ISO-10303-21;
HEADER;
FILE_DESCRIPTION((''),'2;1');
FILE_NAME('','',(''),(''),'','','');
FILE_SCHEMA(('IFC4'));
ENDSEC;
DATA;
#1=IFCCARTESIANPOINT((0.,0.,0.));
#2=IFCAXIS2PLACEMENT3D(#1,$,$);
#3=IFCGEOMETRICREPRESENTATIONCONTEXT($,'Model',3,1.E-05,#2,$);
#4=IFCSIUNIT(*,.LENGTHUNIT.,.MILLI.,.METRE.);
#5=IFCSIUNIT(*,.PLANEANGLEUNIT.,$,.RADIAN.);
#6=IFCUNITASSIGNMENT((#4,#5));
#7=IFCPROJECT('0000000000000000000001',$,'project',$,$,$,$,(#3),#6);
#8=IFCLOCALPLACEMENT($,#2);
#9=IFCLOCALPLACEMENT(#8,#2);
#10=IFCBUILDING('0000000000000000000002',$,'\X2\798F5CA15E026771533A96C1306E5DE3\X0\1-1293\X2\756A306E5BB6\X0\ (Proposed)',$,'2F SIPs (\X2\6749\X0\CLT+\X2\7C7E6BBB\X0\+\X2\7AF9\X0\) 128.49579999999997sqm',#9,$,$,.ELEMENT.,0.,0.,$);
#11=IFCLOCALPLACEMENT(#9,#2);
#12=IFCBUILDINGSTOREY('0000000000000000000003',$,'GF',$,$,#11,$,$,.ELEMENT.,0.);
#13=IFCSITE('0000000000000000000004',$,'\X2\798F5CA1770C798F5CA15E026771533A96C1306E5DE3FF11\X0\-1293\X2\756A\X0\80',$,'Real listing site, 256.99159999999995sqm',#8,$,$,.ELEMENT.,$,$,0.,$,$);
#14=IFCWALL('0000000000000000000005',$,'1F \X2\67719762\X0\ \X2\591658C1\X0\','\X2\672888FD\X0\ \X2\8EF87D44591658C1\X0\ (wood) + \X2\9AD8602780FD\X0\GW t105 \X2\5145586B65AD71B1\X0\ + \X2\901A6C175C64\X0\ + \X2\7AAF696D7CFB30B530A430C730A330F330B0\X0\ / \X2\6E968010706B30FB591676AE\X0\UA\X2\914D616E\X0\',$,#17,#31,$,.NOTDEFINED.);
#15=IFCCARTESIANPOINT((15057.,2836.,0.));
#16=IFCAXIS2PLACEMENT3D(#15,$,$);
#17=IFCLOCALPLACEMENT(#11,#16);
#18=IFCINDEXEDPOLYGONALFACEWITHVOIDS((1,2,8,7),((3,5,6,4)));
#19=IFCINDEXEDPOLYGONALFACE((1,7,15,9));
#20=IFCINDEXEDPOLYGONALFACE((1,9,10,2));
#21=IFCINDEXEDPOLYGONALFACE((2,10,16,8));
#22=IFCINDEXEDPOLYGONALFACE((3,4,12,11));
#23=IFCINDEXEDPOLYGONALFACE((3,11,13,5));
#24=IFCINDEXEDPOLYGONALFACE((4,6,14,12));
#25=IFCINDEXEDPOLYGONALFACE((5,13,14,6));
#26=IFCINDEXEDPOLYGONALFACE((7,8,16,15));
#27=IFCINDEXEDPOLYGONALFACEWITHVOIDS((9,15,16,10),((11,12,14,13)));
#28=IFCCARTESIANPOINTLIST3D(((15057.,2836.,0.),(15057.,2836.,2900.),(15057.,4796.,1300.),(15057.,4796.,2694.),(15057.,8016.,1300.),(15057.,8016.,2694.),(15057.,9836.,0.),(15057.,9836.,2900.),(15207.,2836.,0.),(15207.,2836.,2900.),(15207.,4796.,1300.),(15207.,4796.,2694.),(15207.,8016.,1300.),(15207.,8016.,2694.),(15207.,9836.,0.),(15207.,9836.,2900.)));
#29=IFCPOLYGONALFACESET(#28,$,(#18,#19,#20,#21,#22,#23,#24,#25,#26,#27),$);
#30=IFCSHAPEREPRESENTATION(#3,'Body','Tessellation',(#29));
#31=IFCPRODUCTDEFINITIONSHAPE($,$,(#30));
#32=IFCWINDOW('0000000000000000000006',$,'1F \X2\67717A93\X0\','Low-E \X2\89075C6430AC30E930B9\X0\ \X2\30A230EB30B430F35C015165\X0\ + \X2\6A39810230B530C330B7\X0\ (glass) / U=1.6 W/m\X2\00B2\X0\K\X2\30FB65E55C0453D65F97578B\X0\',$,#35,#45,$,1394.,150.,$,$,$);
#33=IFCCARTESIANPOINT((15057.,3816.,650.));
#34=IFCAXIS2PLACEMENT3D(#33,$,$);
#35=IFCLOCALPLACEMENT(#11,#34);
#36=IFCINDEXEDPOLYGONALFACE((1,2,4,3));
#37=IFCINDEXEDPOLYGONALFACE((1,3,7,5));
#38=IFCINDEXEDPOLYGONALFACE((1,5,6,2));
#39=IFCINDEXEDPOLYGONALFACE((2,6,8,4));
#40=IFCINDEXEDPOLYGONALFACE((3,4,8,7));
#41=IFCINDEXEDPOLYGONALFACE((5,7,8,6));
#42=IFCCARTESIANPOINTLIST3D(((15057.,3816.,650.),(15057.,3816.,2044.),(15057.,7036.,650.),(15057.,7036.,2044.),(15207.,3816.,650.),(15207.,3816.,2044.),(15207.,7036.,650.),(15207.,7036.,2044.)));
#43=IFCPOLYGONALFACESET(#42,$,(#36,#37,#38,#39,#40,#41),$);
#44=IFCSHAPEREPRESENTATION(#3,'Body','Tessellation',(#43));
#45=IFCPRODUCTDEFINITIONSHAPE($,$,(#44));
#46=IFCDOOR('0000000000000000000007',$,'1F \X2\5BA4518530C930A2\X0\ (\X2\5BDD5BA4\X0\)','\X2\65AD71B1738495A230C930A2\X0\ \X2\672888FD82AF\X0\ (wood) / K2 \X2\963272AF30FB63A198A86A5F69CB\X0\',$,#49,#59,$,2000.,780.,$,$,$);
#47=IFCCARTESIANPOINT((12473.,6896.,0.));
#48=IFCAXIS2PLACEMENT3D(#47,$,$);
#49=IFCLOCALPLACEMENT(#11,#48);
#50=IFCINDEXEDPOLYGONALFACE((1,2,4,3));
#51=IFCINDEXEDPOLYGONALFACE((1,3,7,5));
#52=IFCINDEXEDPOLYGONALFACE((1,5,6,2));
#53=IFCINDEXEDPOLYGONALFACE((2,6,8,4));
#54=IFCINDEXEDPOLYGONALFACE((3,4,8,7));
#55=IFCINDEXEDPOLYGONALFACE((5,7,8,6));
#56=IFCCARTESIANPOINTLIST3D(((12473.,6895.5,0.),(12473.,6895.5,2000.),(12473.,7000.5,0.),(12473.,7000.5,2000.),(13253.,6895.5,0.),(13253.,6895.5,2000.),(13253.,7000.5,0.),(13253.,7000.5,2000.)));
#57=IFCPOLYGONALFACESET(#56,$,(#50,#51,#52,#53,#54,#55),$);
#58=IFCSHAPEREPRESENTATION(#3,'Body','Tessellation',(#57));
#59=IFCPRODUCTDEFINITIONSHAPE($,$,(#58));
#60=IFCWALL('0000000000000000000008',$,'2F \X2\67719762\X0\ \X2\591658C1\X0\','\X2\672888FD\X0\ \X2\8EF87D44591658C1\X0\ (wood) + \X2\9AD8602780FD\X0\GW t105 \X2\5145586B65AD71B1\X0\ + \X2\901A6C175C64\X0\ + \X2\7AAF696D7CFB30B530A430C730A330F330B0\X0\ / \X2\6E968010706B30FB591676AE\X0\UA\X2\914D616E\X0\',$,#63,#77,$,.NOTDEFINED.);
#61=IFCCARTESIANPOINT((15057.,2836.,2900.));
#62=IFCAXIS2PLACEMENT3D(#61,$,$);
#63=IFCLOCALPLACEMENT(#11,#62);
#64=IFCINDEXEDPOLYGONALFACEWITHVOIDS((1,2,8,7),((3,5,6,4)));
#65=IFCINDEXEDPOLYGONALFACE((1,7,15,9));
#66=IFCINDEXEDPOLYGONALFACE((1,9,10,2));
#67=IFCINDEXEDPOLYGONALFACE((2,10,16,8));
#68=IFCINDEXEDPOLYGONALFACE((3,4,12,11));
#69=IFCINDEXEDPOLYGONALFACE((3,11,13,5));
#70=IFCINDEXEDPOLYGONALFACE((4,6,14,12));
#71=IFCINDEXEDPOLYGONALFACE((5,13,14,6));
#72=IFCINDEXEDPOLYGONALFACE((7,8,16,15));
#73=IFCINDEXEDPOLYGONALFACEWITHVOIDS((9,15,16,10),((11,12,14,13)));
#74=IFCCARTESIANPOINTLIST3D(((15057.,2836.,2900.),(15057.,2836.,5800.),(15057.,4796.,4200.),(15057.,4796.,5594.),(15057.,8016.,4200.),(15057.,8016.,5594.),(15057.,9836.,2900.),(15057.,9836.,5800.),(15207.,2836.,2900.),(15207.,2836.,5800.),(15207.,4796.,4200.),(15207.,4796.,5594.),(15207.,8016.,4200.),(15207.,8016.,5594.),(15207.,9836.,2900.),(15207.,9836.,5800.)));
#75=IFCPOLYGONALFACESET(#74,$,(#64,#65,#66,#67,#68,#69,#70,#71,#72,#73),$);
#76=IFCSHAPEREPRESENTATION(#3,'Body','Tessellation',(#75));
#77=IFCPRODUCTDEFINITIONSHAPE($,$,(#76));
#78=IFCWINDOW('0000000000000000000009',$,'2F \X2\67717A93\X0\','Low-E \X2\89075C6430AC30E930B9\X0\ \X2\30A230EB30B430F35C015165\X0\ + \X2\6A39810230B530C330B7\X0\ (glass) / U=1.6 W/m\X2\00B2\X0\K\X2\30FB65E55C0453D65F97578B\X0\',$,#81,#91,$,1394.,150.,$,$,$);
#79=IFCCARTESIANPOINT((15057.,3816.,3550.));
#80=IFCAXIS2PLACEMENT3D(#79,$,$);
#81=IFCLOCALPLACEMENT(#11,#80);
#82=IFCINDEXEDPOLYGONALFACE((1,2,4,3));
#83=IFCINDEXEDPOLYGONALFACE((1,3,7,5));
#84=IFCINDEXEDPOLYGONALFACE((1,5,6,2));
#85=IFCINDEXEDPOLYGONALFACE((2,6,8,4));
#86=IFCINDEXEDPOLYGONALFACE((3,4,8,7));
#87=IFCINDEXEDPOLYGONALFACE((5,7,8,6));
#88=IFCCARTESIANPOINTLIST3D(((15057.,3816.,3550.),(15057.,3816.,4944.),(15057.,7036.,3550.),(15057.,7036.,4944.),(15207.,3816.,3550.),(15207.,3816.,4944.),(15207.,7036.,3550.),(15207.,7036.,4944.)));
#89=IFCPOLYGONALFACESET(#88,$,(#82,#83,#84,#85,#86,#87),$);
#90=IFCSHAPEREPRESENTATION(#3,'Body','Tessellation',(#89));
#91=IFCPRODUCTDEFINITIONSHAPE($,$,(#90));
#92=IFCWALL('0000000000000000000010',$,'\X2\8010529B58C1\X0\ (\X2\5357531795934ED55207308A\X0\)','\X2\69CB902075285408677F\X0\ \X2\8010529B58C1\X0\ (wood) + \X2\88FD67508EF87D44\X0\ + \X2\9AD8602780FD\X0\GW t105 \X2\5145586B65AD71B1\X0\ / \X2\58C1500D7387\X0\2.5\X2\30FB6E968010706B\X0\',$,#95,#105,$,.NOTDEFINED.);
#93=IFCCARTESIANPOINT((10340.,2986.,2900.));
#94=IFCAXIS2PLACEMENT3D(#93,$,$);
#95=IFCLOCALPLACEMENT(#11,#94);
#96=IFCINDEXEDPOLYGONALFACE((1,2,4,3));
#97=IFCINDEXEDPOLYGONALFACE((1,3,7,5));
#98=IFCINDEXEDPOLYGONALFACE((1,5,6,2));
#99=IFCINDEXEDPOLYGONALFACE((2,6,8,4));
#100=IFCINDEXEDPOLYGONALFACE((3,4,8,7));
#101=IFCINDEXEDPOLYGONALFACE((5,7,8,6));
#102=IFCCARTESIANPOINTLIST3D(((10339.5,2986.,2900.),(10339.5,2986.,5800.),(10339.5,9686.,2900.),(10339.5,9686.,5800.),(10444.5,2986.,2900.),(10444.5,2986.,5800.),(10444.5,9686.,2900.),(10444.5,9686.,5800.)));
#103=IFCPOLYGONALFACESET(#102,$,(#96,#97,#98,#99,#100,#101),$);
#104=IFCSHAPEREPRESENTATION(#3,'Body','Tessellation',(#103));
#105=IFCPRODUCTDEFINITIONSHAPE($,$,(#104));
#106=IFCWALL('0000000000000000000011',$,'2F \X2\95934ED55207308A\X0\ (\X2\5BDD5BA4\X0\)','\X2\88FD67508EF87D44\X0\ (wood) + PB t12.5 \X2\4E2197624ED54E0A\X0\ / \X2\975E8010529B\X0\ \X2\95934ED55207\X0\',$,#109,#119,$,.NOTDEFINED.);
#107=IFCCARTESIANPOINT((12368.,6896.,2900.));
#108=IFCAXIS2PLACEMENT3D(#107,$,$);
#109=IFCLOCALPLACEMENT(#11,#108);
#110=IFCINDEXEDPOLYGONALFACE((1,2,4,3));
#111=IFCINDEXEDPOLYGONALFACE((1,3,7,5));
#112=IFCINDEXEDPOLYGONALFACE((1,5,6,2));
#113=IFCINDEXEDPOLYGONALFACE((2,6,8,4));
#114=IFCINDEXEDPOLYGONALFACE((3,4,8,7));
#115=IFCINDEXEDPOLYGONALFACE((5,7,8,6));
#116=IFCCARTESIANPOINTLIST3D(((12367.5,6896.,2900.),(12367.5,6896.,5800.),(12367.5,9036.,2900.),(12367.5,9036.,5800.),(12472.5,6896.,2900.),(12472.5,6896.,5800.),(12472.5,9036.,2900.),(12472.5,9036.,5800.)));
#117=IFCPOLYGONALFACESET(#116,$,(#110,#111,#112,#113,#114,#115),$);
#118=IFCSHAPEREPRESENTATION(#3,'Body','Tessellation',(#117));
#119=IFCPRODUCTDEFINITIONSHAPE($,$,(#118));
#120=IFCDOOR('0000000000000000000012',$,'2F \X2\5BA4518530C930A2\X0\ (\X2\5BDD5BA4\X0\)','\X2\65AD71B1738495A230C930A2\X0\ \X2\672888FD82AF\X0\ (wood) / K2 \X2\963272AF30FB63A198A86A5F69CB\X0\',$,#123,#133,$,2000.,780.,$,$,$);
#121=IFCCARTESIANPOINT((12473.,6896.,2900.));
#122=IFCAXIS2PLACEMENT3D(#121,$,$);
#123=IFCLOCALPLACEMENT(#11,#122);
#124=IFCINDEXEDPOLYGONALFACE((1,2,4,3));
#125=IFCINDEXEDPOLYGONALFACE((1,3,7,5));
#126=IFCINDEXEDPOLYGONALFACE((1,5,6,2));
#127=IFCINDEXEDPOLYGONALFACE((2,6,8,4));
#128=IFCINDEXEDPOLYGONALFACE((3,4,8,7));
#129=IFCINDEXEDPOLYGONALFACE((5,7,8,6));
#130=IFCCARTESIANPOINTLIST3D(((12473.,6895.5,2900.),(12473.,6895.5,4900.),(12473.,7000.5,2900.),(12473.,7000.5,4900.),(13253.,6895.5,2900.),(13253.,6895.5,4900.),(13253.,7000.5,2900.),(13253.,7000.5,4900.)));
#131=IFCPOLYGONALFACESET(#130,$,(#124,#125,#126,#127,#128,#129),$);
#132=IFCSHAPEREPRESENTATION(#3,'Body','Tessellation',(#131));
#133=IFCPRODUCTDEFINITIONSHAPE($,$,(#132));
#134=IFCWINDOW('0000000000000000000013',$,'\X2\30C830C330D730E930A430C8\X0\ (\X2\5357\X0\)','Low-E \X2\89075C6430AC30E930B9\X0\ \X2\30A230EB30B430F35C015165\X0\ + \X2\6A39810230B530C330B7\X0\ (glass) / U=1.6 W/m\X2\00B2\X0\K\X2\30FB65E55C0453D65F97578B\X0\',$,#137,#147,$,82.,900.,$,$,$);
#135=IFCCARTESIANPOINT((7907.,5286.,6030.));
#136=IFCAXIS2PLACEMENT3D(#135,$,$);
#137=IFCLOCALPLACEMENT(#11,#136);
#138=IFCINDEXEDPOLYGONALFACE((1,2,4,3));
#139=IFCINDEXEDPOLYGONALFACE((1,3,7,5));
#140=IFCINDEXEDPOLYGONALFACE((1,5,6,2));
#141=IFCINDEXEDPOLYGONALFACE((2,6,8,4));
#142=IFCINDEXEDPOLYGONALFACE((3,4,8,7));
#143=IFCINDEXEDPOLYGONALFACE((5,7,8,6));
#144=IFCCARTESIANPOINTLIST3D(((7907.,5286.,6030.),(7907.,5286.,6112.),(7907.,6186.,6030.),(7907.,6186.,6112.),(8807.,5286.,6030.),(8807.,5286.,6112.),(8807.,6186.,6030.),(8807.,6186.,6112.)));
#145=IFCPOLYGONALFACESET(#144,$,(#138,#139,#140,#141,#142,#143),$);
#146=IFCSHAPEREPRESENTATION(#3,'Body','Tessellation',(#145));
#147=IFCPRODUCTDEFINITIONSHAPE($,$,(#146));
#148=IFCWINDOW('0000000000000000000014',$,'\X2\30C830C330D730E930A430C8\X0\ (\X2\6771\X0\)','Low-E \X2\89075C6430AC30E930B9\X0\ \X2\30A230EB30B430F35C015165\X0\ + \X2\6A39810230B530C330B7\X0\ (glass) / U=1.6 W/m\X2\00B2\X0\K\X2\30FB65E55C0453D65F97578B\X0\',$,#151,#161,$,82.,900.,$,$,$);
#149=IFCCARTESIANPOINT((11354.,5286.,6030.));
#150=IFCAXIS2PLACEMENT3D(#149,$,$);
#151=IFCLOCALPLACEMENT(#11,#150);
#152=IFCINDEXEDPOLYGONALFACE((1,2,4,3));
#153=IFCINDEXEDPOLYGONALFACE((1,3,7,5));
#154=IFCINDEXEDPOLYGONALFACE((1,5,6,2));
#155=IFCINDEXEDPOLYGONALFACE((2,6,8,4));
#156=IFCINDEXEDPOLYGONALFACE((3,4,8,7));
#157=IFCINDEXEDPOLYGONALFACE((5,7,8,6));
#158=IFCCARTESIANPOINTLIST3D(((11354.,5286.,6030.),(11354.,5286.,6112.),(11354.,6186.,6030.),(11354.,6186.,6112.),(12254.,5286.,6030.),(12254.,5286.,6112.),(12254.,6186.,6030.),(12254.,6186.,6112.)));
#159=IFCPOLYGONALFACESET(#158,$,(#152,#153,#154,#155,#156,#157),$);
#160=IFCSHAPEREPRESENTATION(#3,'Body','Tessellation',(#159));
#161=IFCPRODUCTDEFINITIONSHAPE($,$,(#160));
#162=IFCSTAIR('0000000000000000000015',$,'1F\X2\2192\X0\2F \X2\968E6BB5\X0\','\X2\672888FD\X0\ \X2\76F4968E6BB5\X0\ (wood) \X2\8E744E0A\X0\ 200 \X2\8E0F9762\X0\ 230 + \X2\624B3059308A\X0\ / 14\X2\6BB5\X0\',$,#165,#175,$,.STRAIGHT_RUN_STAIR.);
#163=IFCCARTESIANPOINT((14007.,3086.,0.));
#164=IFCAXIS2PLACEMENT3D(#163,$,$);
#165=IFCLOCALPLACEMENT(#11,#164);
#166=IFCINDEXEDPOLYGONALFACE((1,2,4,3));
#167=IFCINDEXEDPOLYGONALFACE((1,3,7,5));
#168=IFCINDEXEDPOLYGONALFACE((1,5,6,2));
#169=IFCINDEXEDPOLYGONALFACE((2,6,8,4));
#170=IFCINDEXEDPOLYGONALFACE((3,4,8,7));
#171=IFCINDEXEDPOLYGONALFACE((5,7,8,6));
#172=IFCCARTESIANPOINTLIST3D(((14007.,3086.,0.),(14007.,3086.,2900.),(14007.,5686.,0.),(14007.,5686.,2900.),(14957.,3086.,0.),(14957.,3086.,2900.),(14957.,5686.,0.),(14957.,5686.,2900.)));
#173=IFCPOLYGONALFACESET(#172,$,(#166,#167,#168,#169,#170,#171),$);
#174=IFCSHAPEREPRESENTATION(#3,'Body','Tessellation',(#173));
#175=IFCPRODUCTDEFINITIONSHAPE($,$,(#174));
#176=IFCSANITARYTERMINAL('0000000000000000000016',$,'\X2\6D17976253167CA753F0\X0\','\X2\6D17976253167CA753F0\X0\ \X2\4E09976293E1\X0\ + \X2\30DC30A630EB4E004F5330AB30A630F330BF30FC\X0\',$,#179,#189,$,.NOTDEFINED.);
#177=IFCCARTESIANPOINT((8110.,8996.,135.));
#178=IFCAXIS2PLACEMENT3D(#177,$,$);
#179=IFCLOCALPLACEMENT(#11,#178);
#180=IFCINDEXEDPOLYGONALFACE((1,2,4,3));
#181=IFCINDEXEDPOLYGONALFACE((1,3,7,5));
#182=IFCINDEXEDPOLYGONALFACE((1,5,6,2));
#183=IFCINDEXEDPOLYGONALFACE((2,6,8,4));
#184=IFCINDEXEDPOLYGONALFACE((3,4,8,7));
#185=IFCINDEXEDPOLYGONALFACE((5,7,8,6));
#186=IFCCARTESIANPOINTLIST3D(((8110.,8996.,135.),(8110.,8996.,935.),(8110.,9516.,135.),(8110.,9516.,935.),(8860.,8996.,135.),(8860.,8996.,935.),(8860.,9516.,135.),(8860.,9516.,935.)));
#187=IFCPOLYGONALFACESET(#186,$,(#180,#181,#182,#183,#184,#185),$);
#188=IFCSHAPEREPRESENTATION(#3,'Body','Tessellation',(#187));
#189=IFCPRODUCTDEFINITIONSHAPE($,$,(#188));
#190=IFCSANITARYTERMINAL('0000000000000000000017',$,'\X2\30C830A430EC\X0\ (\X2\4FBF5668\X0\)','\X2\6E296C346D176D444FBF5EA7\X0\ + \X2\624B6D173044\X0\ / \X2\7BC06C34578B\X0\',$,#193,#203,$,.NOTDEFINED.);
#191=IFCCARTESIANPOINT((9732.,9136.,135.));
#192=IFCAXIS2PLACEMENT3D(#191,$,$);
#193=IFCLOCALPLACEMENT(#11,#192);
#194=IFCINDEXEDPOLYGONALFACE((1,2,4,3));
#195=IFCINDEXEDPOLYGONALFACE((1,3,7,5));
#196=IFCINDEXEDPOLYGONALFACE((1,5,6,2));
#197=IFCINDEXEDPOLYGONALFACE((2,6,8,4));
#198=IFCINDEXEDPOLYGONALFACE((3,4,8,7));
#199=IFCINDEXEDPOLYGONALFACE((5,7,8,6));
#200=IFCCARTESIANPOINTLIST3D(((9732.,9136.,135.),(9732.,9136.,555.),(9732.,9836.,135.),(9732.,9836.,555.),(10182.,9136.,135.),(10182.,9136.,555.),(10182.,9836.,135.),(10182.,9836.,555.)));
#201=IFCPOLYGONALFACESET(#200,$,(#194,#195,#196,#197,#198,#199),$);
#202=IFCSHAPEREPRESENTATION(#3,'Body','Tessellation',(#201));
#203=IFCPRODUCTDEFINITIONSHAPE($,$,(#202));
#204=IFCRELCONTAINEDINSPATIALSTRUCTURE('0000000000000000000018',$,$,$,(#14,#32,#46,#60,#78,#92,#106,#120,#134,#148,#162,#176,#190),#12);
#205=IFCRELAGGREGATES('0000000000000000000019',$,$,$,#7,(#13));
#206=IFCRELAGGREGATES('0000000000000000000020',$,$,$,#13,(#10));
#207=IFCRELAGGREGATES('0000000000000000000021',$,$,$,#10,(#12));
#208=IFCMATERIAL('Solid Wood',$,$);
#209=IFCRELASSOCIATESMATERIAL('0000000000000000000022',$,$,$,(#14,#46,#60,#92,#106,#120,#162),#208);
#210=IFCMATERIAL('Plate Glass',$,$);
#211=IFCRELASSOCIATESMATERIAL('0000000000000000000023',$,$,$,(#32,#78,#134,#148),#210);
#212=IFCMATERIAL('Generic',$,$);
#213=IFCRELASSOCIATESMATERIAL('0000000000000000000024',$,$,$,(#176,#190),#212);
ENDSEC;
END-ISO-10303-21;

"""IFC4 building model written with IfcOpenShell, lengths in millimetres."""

from ifc_helpers import new_model, si_unit, frame, frame_2d, origin, place, context, project, spatial, rectangle, extrude, material, element, fill, save


model = new_model("IFC4")

# Units and contexts
model_context = context("Model", 3, precision=1e-05, world=origin())
ifc_project = project(units=[si_unit("LENGTHUNIT", "METRE", prefix="MILLI"), si_unit("PLANEANGLEUNIT", "RADIAN")], contexts=[model_context])

# Site, building, storey
site_placement = place(None, origin())
site = spatial("IfcSite", under=ifc_project, at=site_placement, Name="福岡県福岡市東区雁の巣１-1293番80", ObjectType="Real listing site, 256.99159999999995sqm", CompositionType="ELEMENT", RefElevation=0.0)
building_placement = place(site_placement, origin())
building = spatial("IfcBuilding", under=site, at=building_placement, Name="福岡市東区雁の巣1-1293番の家 (Proposed)", ObjectType="2F SIPs (杉CLT+籾殻+竹) 128.49579999999997sqm", CompositionType="ELEMENT", ElevationOfRefHeight=0.0, ElevationOfTerrain=0.0)
storey_placement = place(building_placement, origin())
storey = spatial("IfcBuildingStorey", under=building, at=storey_placement, Name="GF", CompositionType="ELEMENT", Elevation=0.0)

# Wall, opening, window
ifc_material_1 = material(Name="Solid Wood")
wall_1_placement = place(storey_placement, frame((15057.0, 2836.0, 0.0)))
wall_1 = element("IfcWall", 1, at=wall_1_placement, inside=storey, material=ifc_material_1, Name="1F 東面 外壁", Description="木製 軸組外壁 (wood) + 高性能GW t105 充填断熱 + 通気層 + 窯業系サイディング / 準耐火・外皮UA配慮", PredefinedType="NOTDEFINED", context=model_context, shape_type="SweptSolid", body=[
    extrude(rectangle(XDim=150.0, YDim=7000.0, at=frame_2d((75.0, 3500.0))), frame((15057.0, 2836.0, 0.0)), (0.0, 0.0, 1.0), 2900.0),
])
opening_1_placement = place(storey_placement, frame((15057.0, 3816.0, 650.0)))
opening_1 = element("IfcOpeningElement", 2, at=opening_1_placement, cuts=wall_1, PredefinedType="NOTDEFINED", context=model_context, shape_type="SweptSolid", body=[
    extrude(rectangle(XDim=150.0, YDim=3220.0, at=frame_2d((75.0, 1610.0))), frame((15057.0, 3816.0, 650.0)), (0.0, 0.0, 1.0), 1394.0),
])
ifc_material_2 = material(Name="Plate Glass")
window_1_placement = place(storey_placement, frame((15057.0, 3816.0, 650.0)))
window_1 = element("IfcWindow", 3, at=window_1_placement, inside=storey, material=ifc_material_2, Name="1F 東窓", Description="Low-E 複層ガラス アルゴン封入 + 樹脂サッシ (glass) / U=1.6 W/m²K・日射取得型", OverallHeight=1394.0, OverallWidth=150.0, context=model_context, shape_type="SweptSolid", body=[
    extrude(rectangle(XDim=150.0, YDim=3220.0, at=frame_2d((75.0, 1610.0))), frame((15057.0, 3816.0, 650.0)), (0.0, 0.0, 1.0), 1394.0),
])
fill(opening_1, window_1)

# Door
door_1_placement = place(storey_placement, frame((12473.0, 6896.0, 0.0)))
element("IfcDoor", 4, at=door_1_placement, inside=storey, material=ifc_material_1, Name="1F 室内ドア (寝室)", Description="断熱玄関ドア 木製芯 (wood) / K2 防犯・採風機構", OverallHeight=2000.0, OverallWidth=780.0, context=model_context, shape_type="SweptSolid", body=[
    extrude(rectangle(XDim=780.0, YDim=105.0, at=frame_2d((390.0, 52.0))), frame((12473.0, 6896.0, 0.0)), (0.0, 0.0, 1.0), 2000.0),
])

# Wall, opening, window
wall_2_placement = place(storey_placement, frame((15057.0, 2836.0, 2900.0)))
wall_2 = element("IfcWall", 5, at=wall_2_placement, inside=storey, material=ifc_material_1, Name="2F 東面 外壁", Description="木製 軸組外壁 (wood) + 高性能GW t105 充填断熱 + 通気層 + 窯業系サイディング / 準耐火・外皮UA配慮", PredefinedType="NOTDEFINED", context=model_context, shape_type="SweptSolid", body=[
    extrude(rectangle(XDim=150.0, YDim=7000.0, at=frame_2d((75.0, 3500.0))), frame((15057.0, 2836.0, 2900.0)), (0.0, 0.0, 1.0), 2900.0),
])
opening_2_placement = place(storey_placement, frame((15057.0, 3816.0, 3550.0)))
opening_2 = element("IfcOpeningElement", 6, at=opening_2_placement, cuts=wall_2, PredefinedType="NOTDEFINED", context=model_context, shape_type="SweptSolid", body=[
    extrude(rectangle(XDim=150.0, YDim=3220.0, at=frame_2d((75.0, 1610.0))), frame((15057.0, 3816.0, 3550.0)), (0.0, 0.0, 1.0), 1394.0),
])
window_2_placement = place(storey_placement, frame((15057.0, 3816.0, 3550.0)))
window_2 = element("IfcWindow", 7, at=window_2_placement, inside=storey, material=ifc_material_2, Name="2F 東窓", Description="Low-E 複層ガラス アルゴン封入 + 樹脂サッシ (glass) / U=1.6 W/m²K・日射取得型", OverallHeight=1394.0, OverallWidth=150.0, context=model_context, shape_type="SweptSolid", body=[
    extrude(rectangle(XDim=150.0, YDim=3220.0, at=frame_2d((75.0, 1610.0))), frame((15057.0, 3816.0, 3550.0)), (0.0, 0.0, 1.0), 1394.0),
])
fill(opening_2, window_2)

# Walls
wall_3_placement = place(storey_placement, frame((10340.0, 2986.0, 2900.0)))
element("IfcWall", 8, at=wall_3_placement, inside=storey, material=ifc_material_1, Name="耐力壁 (南北間仕切り)", Description="構造用合板 耐力壁 (wood) + 製材軸組 + 高性能GW t105 充填断熱 / 壁倍率2.5・準耐火", PredefinedType="NOTDEFINED", context=model_context, shape_type="SweptSolid", body=[
    extrude(rectangle(XDim=105.0, YDim=6700.0, at=frame_2d((52.0, 3350.0))), frame((10340.0, 2986.0, 2900.0)), (0.0, 0.0, 1.0), 2900.0),
])
wall_4_placement = place(storey_placement, frame((12368.0, 6896.0, 2900.0)))
element("IfcWall", 9, at=wall_4_placement, inside=storey, material=ifc_material_1, Name="2F 間仕切り (寝室)", Description="製材軸組 (wood) + PB t12.5 両面仕上 / 非耐力 間仕切", PredefinedType="NOTDEFINED", context=model_context, shape_type="SweptSolid", body=[
    extrude(rectangle(XDim=105.0, YDim=2140.0, at=frame_2d((52.0, 1070.0))), frame((12368.0, 6896.0, 2900.0)), (0.0, 0.0, 1.0), 2900.0),
])

# Door
door_2_placement = place(storey_placement, frame((12473.0, 6896.0, 2900.0)))
element("IfcDoor", 10, at=door_2_placement, inside=storey, material=ifc_material_1, Name="2F 室内ドア (寝室)", Description="断熱玄関ドア 木製芯 (wood) / K2 防犯・採風機構", OverallHeight=2000.0, OverallWidth=780.0, context=model_context, shape_type="SweptSolid", body=[
    extrude(rectangle(XDim=780.0, YDim=105.0, at=frame_2d((390.0, 52.0))), frame((12473.0, 6896.0, 2900.0)), (0.0, 0.0, 1.0), 2000.0),
])

# Windows
window_3_placement = place(storey_placement, frame((7907.0, 5286.0, 6030.0)))
element("IfcWindow", 11, at=window_3_placement, inside=storey, material=ifc_material_2, Name="トップライト (南)", Description="Low-E 複層ガラス アルゴン封入 + 樹脂サッシ (glass) / U=1.6 W/m²K・日射取得型", OverallHeight=82.0, OverallWidth=900.0, context=model_context, shape_type="SweptSolid", body=[
    extrude(rectangle(XDim=900.0, YDim=900.0, at=frame_2d((450.0, 450.0))), frame((7907.0, 5286.0, 6030.0)), (0.0, 0.0, 1.0), 82.0),
])
window_4_placement = place(storey_placement, frame((11354.0, 5286.0, 6030.0)))
element("IfcWindow", 12, at=window_4_placement, inside=storey, material=ifc_material_2, Name="トップライト (東)", Description="Low-E 複層ガラス アルゴン封入 + 樹脂サッシ (glass) / U=1.6 W/m²K・日射取得型", OverallHeight=82.0, OverallWidth=900.0, context=model_context, shape_type="SweptSolid", body=[
    extrude(rectangle(XDim=900.0, YDim=900.0, at=frame_2d((450.0, 450.0))), frame((11354.0, 5286.0, 6030.0)), (0.0, 0.0, 1.0), 82.0),
])

# Stair
stair_placement = place(storey_placement, frame((14007.0, 3086.0, 0.0)))
element("IfcStair", 13, at=stair_placement, inside=storey, material=ifc_material_1, Name="1F→2F 階段", Description="木製 直階段 (wood) 蹴上 200 踏面 230 + 手すり / 14段", PredefinedType="STRAIGHT_RUN_STAIR", context=model_context, shape_type="SweptSolid", body=[
    extrude(rectangle(XDim=950.0, YDim=2600.0, at=frame_2d((475.0, 1300.0))), frame((14007.0, 3086.0, 0.0)), (0.0, 0.0, 1.0), 2900.0),
])

# Sanitary terminals
ifc_material_3 = material(Name="Generic")
sanitary_terminal_1_placement = place(storey_placement, frame((8110.0, 8996.0, 135.0)))
element("IfcSanitaryTerminal", 14, at=sanitary_terminal_1_placement, inside=storey, material=ifc_material_3, Name="洗面化粧台", Description="洗面化粧台 三面鏡 + ボウル一体カウンター", PredefinedType="NOTDEFINED", context=model_context, shape_type="SweptSolid", body=[
    extrude(rectangle(XDim=750.0, YDim=520.0, at=frame_2d((375.0, 260.0))), frame((8110.0, 8996.0, 135.0)), (0.0, 0.0, 1.0), 800.0),
])
sanitary_terminal_2_placement = place(storey_placement, frame((9732.0, 9136.0, 135.0)))
element("IfcSanitaryTerminal", 15, at=sanitary_terminal_2_placement, inside=storey, material=ifc_material_3, Name="トイレ (便器)", Description="温水洗浄便座 + 手洗い / 節水型", PredefinedType="NOTDEFINED", context=model_context, shape_type="SweptSolid", body=[
    extrude(rectangle(XDim=450.0, YDim=700.0, at=frame_2d((225.0, 350.0))), frame((9732.0, 9136.0, 135.0)), (0.0, 0.0, 1.0), 420.0),
])

save(model, "model.ifc")
